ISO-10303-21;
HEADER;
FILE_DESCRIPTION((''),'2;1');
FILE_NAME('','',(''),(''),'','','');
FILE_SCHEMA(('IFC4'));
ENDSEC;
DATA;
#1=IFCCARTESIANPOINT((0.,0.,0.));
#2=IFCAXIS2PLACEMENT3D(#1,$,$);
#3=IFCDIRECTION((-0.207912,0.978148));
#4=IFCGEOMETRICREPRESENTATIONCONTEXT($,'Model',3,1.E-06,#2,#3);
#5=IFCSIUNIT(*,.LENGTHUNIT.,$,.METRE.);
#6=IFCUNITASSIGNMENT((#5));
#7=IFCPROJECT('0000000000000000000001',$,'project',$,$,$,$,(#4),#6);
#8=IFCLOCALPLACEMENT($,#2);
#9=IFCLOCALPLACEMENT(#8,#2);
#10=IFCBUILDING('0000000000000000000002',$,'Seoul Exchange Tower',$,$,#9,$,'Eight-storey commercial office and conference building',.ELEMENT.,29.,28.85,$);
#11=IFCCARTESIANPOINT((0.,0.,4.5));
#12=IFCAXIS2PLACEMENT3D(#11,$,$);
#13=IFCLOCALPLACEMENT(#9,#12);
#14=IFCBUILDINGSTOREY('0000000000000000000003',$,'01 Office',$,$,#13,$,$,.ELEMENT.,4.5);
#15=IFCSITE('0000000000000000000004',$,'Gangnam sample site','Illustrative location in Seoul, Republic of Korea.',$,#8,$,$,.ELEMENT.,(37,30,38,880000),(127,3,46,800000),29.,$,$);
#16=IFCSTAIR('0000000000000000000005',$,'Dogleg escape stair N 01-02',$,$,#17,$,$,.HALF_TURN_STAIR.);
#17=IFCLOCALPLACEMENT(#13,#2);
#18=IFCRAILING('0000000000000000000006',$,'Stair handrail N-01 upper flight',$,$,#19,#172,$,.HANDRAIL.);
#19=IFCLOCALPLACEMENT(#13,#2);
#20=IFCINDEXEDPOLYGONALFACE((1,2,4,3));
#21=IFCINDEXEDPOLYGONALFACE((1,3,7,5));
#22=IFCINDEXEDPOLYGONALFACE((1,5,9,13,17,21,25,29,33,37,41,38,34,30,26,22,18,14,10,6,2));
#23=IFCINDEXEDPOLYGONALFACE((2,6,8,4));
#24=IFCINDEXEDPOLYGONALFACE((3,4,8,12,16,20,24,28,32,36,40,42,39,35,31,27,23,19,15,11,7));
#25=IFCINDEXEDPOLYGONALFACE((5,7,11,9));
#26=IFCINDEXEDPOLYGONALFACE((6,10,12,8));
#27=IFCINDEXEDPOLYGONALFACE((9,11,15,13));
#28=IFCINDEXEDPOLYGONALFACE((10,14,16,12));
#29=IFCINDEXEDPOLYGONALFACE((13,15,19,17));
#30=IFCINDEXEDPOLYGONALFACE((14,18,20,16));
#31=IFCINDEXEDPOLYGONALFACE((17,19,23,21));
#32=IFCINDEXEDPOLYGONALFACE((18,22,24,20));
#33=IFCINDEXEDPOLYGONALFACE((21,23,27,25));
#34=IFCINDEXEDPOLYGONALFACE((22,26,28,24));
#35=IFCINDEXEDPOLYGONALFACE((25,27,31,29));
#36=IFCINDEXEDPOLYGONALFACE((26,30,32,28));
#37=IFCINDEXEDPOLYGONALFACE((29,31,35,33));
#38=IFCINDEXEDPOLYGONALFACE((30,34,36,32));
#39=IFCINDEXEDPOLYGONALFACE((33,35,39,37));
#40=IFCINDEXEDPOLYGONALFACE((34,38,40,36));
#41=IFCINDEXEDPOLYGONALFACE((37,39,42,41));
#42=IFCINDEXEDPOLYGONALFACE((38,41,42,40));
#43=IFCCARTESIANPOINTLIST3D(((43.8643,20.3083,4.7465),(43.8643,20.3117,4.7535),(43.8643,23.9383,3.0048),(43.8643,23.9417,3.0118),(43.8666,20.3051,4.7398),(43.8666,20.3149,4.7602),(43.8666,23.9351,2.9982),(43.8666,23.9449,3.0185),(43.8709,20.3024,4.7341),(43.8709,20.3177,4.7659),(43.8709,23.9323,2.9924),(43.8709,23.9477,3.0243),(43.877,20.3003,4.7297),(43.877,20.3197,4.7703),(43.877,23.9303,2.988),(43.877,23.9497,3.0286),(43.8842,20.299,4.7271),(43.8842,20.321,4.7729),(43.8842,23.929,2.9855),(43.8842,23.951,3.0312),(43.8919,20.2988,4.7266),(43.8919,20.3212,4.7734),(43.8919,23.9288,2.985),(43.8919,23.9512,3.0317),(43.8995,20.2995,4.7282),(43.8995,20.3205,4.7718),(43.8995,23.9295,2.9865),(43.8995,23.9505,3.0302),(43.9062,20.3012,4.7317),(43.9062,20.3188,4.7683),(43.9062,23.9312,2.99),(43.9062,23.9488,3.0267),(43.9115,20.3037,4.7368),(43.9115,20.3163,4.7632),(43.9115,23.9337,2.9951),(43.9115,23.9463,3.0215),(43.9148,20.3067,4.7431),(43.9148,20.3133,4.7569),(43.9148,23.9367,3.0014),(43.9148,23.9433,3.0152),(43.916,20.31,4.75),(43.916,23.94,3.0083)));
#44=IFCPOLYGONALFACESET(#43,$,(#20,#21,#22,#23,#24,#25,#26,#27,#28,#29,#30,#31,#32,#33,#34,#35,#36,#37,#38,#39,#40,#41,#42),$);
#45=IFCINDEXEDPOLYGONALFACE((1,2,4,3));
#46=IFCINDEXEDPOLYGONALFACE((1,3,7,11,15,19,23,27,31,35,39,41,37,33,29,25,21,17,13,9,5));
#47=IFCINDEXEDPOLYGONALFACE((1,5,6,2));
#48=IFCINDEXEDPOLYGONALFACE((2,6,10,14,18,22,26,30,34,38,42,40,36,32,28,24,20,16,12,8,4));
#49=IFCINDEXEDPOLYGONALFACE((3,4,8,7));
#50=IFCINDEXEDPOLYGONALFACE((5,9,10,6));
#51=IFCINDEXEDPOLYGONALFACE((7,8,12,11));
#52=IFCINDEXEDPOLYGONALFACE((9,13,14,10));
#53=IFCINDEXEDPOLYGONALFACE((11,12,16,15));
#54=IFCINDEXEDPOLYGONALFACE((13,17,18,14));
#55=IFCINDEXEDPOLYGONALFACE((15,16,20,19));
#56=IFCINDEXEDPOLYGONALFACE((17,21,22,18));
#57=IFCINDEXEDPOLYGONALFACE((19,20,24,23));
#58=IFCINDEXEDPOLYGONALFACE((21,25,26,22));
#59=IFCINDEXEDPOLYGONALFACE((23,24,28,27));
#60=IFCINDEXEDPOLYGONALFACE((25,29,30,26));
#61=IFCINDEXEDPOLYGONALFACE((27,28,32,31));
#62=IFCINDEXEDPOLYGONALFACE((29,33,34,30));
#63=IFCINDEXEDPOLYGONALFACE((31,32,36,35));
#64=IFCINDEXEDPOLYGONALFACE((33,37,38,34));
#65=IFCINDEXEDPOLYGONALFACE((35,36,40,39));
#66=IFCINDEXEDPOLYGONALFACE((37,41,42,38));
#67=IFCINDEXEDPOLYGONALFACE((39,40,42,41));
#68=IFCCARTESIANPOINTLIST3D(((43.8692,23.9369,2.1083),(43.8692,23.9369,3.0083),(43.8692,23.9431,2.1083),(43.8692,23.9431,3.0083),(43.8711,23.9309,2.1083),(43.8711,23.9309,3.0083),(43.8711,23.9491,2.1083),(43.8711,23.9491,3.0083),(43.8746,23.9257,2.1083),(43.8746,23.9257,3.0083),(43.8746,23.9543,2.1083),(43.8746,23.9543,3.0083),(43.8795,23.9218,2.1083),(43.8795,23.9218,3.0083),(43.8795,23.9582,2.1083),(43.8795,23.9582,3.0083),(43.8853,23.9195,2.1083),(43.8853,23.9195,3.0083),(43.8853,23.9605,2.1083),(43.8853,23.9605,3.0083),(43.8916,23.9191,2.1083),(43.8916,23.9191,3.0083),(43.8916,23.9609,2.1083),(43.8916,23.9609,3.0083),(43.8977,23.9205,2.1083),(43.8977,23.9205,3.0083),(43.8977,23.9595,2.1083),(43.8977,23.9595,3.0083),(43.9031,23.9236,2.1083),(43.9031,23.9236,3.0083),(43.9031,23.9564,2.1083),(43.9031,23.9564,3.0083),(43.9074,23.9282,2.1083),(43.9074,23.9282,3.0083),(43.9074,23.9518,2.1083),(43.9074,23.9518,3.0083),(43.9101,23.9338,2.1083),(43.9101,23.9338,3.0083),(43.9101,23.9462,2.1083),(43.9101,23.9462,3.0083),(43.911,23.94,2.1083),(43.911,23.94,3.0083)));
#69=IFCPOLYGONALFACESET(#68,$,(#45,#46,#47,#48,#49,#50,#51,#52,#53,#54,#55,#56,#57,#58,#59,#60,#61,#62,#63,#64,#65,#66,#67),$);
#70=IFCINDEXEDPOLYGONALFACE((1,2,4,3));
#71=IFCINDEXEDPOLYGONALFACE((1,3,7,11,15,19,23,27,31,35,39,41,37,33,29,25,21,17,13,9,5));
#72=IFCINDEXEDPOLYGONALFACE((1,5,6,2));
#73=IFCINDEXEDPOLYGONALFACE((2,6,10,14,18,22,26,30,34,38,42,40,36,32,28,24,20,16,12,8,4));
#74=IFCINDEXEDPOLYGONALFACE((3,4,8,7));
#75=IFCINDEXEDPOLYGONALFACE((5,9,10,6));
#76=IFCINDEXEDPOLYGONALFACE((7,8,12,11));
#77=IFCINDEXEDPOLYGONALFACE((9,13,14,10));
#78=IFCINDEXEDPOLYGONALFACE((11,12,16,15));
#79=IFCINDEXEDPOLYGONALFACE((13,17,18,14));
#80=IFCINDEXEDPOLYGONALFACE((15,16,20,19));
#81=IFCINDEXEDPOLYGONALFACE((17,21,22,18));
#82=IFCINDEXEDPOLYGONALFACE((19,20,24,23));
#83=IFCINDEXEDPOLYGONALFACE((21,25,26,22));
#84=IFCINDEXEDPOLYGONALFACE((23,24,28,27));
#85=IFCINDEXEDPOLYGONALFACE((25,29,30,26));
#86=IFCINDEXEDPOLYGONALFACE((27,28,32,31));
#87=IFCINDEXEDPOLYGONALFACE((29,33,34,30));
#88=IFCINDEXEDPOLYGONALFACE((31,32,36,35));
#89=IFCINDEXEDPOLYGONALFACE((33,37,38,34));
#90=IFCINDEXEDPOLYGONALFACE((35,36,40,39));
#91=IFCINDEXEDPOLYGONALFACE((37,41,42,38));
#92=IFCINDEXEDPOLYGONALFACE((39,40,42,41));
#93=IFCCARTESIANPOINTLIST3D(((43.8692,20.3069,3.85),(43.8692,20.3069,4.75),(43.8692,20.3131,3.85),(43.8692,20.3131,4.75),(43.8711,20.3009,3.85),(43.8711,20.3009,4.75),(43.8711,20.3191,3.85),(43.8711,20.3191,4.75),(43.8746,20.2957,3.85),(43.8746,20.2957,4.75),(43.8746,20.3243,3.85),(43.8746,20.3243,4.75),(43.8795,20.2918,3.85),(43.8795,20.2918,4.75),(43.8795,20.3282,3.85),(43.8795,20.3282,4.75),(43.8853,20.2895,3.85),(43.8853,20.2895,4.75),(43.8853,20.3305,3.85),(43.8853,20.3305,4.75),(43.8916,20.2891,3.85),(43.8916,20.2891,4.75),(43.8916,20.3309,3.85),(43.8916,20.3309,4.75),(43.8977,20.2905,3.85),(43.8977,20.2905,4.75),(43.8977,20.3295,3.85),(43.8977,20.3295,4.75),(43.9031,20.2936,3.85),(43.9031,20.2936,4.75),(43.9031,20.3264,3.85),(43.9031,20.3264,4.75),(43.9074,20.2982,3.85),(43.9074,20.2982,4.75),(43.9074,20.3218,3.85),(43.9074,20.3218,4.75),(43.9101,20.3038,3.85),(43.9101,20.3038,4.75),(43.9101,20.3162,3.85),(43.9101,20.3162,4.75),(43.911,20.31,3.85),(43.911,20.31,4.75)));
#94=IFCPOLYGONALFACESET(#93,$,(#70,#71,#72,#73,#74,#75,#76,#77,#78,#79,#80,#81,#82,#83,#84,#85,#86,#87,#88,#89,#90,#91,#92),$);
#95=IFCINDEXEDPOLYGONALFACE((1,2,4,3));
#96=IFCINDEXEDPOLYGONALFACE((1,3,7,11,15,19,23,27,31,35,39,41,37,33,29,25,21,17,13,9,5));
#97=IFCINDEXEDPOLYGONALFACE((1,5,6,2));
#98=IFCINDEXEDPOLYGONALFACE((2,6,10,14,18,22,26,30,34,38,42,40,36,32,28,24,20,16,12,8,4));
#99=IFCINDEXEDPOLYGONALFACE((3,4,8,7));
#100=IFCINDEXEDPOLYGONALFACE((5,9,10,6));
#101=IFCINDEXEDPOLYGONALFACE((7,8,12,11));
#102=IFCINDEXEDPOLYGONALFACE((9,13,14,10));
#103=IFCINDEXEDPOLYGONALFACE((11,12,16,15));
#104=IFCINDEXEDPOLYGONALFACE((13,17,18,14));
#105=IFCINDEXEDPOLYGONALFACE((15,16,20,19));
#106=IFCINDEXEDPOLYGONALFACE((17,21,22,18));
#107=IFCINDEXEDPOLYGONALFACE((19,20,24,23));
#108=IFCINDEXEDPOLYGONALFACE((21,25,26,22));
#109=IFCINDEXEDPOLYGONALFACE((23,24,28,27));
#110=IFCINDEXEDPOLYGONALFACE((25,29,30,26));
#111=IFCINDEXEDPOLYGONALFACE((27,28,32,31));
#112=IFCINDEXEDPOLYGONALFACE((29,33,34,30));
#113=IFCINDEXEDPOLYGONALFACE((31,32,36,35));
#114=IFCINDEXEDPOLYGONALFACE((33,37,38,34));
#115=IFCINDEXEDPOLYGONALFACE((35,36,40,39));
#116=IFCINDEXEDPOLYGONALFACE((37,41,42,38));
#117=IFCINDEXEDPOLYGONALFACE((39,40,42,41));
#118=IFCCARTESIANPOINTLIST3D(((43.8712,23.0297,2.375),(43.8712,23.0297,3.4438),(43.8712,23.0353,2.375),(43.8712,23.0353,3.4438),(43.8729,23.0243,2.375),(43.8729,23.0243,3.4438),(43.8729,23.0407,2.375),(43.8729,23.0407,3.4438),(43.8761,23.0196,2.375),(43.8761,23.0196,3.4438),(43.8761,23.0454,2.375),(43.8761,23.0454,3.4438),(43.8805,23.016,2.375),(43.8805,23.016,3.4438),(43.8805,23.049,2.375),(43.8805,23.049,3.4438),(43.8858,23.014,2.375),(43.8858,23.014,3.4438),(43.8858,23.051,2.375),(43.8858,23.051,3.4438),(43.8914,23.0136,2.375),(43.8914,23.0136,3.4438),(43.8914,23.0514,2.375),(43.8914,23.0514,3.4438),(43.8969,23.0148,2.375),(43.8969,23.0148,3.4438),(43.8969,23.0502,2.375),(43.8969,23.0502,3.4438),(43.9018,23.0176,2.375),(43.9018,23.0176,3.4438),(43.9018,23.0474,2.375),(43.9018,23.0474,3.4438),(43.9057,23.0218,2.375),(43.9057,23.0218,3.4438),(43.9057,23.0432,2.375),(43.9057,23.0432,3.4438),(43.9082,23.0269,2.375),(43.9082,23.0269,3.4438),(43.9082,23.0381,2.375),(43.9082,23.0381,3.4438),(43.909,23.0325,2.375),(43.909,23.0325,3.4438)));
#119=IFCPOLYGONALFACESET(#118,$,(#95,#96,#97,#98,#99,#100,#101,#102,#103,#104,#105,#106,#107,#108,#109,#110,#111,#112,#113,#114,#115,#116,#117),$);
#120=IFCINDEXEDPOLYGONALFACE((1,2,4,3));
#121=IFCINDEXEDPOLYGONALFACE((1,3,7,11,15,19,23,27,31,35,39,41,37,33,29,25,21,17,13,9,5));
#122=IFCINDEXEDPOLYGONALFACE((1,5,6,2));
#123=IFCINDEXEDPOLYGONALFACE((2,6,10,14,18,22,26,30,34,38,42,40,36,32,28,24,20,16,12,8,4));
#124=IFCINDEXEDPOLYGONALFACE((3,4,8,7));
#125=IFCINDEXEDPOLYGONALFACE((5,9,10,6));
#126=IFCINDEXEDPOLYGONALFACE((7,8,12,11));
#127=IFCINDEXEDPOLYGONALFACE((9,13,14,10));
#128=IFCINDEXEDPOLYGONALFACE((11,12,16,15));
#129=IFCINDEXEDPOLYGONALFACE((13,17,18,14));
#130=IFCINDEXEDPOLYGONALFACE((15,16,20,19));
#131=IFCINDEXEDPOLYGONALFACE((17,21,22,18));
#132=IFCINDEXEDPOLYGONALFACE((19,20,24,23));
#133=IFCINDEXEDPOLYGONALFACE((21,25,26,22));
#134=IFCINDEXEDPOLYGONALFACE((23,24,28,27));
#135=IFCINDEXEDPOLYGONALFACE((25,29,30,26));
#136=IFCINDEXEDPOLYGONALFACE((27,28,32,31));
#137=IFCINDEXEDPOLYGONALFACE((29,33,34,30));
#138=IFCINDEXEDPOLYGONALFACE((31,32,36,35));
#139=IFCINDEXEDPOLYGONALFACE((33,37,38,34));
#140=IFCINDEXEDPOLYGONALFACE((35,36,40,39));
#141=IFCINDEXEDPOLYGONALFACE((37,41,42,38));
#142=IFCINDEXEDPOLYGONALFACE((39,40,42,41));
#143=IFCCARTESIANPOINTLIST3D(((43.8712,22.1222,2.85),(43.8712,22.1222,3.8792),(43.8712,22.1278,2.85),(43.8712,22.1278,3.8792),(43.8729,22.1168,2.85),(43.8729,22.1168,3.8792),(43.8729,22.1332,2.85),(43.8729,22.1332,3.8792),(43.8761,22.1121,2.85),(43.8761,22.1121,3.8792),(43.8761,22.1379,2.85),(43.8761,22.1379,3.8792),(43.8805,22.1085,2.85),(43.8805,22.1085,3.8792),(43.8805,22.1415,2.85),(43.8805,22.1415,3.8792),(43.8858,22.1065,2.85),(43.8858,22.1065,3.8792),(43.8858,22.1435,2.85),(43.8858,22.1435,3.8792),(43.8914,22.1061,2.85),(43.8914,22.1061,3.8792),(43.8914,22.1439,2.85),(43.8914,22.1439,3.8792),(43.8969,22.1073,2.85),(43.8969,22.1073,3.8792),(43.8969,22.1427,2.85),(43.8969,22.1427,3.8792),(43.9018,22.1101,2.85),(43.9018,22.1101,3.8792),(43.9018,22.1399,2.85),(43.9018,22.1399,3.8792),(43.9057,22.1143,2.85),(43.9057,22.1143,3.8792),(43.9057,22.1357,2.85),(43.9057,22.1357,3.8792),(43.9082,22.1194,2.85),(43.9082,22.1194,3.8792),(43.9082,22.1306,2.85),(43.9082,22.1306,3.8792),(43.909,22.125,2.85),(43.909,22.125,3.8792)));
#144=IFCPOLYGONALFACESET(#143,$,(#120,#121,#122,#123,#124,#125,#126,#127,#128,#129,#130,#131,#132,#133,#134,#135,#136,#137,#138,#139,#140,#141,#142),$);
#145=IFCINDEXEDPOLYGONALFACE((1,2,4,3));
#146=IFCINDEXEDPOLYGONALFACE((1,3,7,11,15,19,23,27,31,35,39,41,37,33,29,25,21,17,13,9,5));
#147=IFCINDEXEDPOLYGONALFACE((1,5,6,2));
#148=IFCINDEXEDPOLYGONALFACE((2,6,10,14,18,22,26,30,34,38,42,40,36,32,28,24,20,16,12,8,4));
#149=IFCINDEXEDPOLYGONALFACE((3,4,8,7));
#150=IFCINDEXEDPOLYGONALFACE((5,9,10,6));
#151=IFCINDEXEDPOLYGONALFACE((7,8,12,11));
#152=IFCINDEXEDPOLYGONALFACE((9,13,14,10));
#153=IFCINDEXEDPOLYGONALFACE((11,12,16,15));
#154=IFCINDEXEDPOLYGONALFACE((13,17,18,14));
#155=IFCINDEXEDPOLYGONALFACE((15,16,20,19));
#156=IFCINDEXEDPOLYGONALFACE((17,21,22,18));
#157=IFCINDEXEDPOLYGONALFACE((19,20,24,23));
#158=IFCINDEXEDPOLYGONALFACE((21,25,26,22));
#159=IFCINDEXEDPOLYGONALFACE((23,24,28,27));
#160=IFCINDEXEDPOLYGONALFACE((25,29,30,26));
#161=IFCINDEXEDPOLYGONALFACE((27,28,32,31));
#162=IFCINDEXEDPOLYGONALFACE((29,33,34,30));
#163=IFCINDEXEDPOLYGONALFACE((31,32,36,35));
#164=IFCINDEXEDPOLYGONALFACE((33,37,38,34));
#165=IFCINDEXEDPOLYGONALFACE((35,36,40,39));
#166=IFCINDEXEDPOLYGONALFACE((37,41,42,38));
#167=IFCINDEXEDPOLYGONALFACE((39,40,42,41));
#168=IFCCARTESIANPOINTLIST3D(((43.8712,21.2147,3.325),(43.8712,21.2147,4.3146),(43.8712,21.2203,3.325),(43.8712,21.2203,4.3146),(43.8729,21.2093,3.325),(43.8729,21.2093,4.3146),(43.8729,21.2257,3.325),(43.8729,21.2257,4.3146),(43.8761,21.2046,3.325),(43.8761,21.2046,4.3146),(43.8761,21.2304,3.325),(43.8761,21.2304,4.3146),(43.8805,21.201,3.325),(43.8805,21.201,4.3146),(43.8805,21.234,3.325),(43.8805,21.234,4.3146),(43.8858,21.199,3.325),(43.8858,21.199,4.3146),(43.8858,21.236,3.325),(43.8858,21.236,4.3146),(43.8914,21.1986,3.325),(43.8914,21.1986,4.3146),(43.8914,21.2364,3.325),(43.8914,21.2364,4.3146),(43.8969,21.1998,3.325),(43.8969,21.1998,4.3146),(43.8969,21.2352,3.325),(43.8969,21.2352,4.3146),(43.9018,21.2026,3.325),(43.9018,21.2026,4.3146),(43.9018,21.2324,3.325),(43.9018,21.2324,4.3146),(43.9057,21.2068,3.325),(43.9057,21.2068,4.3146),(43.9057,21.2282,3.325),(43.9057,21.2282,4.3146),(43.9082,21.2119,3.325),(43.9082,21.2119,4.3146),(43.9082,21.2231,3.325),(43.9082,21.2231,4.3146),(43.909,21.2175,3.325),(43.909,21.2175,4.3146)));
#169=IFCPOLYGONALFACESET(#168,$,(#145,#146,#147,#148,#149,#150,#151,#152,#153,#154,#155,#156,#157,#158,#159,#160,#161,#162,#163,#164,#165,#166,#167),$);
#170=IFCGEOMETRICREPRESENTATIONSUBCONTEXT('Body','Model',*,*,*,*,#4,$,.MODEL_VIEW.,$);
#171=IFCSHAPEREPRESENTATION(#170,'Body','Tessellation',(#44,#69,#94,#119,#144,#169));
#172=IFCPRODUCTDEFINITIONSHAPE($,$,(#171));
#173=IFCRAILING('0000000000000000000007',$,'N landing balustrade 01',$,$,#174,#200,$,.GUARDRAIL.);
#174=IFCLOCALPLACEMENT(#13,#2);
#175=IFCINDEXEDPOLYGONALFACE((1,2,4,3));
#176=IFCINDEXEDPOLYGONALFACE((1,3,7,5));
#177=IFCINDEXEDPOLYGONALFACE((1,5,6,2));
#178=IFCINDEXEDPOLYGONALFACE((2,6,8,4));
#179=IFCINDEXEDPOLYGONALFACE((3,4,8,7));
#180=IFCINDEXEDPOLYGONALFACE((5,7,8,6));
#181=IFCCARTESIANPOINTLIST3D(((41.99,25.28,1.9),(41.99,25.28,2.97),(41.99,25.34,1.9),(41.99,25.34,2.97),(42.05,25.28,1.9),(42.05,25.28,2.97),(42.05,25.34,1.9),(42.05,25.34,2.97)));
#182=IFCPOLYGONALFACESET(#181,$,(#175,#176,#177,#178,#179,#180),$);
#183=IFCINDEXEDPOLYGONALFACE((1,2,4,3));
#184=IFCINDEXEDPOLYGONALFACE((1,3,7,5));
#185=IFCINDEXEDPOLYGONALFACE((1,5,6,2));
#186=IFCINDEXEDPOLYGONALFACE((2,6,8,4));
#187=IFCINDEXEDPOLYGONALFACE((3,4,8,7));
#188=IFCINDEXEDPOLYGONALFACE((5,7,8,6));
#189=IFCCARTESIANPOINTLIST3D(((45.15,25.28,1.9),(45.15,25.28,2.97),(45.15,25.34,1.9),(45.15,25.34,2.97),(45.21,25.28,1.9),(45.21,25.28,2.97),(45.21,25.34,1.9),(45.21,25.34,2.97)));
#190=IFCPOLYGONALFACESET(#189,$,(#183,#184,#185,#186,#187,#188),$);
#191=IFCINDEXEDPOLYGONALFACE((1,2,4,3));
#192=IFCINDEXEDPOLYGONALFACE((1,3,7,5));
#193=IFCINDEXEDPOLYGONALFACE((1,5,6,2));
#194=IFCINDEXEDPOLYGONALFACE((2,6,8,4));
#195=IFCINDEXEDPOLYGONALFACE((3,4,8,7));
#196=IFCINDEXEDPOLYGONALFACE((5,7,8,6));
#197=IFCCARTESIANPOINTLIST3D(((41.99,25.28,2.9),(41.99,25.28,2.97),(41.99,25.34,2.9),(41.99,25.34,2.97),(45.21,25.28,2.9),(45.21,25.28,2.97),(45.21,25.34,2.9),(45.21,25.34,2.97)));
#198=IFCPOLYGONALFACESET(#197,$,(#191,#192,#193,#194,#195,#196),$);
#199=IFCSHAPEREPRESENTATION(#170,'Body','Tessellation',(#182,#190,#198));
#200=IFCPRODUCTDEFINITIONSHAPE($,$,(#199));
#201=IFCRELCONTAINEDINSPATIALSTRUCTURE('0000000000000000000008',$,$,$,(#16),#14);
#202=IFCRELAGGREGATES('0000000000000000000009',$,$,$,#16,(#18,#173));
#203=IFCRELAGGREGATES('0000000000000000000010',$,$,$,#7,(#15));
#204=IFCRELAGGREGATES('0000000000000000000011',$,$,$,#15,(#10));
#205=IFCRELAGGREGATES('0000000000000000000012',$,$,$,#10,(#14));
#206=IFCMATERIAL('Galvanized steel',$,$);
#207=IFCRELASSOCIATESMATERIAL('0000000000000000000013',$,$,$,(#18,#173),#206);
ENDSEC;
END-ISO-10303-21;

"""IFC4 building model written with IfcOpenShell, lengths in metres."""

from ifc_helpers import new_model, si_unit, direction, frame, frame_2d, origin, place, context, subcontext, project, spatial, rectangle, circle, extrude, material, element, aggregate, save


model = new_model("IFC4")

# Units and contexts
model_context = context("Model", 3, precision=1e-06, world=origin(), true_north=direction((-0.207912, 0.978148)))
body_context = subcontext(model_context, "Body", "Model", "MODEL_VIEW")
ifc_project = project(units=[si_unit("LENGTHUNIT", "METRE")], contexts=[model_context])

# Site, building, storey
site_placement = place(None, origin())
site = spatial("IfcSite", under=ifc_project, at=site_placement, Name="Gangnam sample site", Description="Illustrative location in Seoul, Republic of Korea.", CompositionType="ELEMENT", RefLatitude=(37, 30, 38, 880000), RefLongitude=(127, 3, 46, 800000), RefElevation=29.0)
building_placement = place(site_placement, origin())
building = spatial("IfcBuilding", under=site, at=building_placement, Name="Seoul Exchange Tower", LongName="Eight-storey commercial office and conference building", CompositionType="ELEMENT", ElevationOfRefHeight=29.0, ElevationOfTerrain=28.85)
storey_placement = place(building_placement, frame((0.0, 0.0, 4.5)))
storey = spatial("IfcBuildingStorey", under=building, at=storey_placement, Name="01 Office", CompositionType="ELEMENT", Elevation=4.5)

# Shared definitions
placement_1 = place(storey_placement, origin())

# Stair
stair_1 = element("IfcStair", 1, at=placement_1, inside=storey, Name="Dogleg escape stair N 01-02", PredefinedType="HALF_TURN_STAIR")
placement_2 = place(placement_1, origin())

# Railings
ifc_material_1 = material(Name="Galvanized steel")
railing_1 = element("IfcRailing", 2, at=placement_2, material=ifc_material_1, Name="Stair handrail N-01 upper flight", PredefinedType="HANDRAIL", context=body_context, shape_type="SweptSolid", body=[
    extrude(circle(Radius=0.026), frame((43.89, 23.94, 3.0083), z_axis=(0.0, -0.901594, 0.432583), x_axis=(1.0, 0.0, 0.0)), (0.0, 0.0, 1.0), 4.0262),
    extrude(circle(Radius=0.021), frame((43.89, 23.94, 2.1083), z_axis=(0.0, 0.0, 1.0), x_axis=(1.0, 0.0, 0.0)), (0.0, 0.0, 1.0), 0.9),
    extrude(circle(Radius=0.021), frame((43.89, 20.31, 3.85), z_axis=(0.0, 0.0, 1.0), x_axis=(1.0, 0.0, 0.0)), (0.0, 0.0, 1.0), 0.9),
    extrude(circle(Radius=0.019), frame((43.89, 23.0325, 2.375), z_axis=(0.0, 0.0, 1.0), x_axis=(1.0, 0.0, 0.0)), (0.0, 0.0, 1.0), 1.0688),
    extrude(circle(Radius=0.019), frame((43.89, 22.125, 2.85), z_axis=(0.0, 0.0, 1.0), x_axis=(1.0, 0.0, 0.0)), (0.0, 0.0, 1.0), 1.0292),
    extrude(circle(Radius=0.019), frame((43.89, 21.2175, 3.325), z_axis=(0.0, 0.0, 1.0), x_axis=(1.0, 0.0, 0.0)), (0.0, 0.0, 1.0), 0.9896),
])
railing_2 = element("IfcRailing", 3, at=placement_2, material=ifc_material_1, Name="N landing balustrade 01", PredefinedType="GUARDRAIL", context=body_context, shape_type="SweptSolid", body=[
    extrude(rectangle(XDim=0.06, YDim=0.06, at=frame_2d((0.03, 0.03))), frame((41.99, 25.28, 1.9)), (0.0, 0.0, 1.0), 1.07),
    extrude(rectangle(XDim=0.06, YDim=0.06, at=frame_2d((0.03, 0.03))), frame((45.15, 25.28, 1.9)), (0.0, 0.0, 1.0), 1.07),
    extrude(rectangle(XDim=3.22, YDim=0.06, at=frame_2d((1.61, 0.03))), frame((41.99, 25.28, 2.9)), (0.0, 0.0, 1.0), 0.07),
])
aggregate(stair_1, [railing_1, railing_2])

save(model, "model.ifc")
